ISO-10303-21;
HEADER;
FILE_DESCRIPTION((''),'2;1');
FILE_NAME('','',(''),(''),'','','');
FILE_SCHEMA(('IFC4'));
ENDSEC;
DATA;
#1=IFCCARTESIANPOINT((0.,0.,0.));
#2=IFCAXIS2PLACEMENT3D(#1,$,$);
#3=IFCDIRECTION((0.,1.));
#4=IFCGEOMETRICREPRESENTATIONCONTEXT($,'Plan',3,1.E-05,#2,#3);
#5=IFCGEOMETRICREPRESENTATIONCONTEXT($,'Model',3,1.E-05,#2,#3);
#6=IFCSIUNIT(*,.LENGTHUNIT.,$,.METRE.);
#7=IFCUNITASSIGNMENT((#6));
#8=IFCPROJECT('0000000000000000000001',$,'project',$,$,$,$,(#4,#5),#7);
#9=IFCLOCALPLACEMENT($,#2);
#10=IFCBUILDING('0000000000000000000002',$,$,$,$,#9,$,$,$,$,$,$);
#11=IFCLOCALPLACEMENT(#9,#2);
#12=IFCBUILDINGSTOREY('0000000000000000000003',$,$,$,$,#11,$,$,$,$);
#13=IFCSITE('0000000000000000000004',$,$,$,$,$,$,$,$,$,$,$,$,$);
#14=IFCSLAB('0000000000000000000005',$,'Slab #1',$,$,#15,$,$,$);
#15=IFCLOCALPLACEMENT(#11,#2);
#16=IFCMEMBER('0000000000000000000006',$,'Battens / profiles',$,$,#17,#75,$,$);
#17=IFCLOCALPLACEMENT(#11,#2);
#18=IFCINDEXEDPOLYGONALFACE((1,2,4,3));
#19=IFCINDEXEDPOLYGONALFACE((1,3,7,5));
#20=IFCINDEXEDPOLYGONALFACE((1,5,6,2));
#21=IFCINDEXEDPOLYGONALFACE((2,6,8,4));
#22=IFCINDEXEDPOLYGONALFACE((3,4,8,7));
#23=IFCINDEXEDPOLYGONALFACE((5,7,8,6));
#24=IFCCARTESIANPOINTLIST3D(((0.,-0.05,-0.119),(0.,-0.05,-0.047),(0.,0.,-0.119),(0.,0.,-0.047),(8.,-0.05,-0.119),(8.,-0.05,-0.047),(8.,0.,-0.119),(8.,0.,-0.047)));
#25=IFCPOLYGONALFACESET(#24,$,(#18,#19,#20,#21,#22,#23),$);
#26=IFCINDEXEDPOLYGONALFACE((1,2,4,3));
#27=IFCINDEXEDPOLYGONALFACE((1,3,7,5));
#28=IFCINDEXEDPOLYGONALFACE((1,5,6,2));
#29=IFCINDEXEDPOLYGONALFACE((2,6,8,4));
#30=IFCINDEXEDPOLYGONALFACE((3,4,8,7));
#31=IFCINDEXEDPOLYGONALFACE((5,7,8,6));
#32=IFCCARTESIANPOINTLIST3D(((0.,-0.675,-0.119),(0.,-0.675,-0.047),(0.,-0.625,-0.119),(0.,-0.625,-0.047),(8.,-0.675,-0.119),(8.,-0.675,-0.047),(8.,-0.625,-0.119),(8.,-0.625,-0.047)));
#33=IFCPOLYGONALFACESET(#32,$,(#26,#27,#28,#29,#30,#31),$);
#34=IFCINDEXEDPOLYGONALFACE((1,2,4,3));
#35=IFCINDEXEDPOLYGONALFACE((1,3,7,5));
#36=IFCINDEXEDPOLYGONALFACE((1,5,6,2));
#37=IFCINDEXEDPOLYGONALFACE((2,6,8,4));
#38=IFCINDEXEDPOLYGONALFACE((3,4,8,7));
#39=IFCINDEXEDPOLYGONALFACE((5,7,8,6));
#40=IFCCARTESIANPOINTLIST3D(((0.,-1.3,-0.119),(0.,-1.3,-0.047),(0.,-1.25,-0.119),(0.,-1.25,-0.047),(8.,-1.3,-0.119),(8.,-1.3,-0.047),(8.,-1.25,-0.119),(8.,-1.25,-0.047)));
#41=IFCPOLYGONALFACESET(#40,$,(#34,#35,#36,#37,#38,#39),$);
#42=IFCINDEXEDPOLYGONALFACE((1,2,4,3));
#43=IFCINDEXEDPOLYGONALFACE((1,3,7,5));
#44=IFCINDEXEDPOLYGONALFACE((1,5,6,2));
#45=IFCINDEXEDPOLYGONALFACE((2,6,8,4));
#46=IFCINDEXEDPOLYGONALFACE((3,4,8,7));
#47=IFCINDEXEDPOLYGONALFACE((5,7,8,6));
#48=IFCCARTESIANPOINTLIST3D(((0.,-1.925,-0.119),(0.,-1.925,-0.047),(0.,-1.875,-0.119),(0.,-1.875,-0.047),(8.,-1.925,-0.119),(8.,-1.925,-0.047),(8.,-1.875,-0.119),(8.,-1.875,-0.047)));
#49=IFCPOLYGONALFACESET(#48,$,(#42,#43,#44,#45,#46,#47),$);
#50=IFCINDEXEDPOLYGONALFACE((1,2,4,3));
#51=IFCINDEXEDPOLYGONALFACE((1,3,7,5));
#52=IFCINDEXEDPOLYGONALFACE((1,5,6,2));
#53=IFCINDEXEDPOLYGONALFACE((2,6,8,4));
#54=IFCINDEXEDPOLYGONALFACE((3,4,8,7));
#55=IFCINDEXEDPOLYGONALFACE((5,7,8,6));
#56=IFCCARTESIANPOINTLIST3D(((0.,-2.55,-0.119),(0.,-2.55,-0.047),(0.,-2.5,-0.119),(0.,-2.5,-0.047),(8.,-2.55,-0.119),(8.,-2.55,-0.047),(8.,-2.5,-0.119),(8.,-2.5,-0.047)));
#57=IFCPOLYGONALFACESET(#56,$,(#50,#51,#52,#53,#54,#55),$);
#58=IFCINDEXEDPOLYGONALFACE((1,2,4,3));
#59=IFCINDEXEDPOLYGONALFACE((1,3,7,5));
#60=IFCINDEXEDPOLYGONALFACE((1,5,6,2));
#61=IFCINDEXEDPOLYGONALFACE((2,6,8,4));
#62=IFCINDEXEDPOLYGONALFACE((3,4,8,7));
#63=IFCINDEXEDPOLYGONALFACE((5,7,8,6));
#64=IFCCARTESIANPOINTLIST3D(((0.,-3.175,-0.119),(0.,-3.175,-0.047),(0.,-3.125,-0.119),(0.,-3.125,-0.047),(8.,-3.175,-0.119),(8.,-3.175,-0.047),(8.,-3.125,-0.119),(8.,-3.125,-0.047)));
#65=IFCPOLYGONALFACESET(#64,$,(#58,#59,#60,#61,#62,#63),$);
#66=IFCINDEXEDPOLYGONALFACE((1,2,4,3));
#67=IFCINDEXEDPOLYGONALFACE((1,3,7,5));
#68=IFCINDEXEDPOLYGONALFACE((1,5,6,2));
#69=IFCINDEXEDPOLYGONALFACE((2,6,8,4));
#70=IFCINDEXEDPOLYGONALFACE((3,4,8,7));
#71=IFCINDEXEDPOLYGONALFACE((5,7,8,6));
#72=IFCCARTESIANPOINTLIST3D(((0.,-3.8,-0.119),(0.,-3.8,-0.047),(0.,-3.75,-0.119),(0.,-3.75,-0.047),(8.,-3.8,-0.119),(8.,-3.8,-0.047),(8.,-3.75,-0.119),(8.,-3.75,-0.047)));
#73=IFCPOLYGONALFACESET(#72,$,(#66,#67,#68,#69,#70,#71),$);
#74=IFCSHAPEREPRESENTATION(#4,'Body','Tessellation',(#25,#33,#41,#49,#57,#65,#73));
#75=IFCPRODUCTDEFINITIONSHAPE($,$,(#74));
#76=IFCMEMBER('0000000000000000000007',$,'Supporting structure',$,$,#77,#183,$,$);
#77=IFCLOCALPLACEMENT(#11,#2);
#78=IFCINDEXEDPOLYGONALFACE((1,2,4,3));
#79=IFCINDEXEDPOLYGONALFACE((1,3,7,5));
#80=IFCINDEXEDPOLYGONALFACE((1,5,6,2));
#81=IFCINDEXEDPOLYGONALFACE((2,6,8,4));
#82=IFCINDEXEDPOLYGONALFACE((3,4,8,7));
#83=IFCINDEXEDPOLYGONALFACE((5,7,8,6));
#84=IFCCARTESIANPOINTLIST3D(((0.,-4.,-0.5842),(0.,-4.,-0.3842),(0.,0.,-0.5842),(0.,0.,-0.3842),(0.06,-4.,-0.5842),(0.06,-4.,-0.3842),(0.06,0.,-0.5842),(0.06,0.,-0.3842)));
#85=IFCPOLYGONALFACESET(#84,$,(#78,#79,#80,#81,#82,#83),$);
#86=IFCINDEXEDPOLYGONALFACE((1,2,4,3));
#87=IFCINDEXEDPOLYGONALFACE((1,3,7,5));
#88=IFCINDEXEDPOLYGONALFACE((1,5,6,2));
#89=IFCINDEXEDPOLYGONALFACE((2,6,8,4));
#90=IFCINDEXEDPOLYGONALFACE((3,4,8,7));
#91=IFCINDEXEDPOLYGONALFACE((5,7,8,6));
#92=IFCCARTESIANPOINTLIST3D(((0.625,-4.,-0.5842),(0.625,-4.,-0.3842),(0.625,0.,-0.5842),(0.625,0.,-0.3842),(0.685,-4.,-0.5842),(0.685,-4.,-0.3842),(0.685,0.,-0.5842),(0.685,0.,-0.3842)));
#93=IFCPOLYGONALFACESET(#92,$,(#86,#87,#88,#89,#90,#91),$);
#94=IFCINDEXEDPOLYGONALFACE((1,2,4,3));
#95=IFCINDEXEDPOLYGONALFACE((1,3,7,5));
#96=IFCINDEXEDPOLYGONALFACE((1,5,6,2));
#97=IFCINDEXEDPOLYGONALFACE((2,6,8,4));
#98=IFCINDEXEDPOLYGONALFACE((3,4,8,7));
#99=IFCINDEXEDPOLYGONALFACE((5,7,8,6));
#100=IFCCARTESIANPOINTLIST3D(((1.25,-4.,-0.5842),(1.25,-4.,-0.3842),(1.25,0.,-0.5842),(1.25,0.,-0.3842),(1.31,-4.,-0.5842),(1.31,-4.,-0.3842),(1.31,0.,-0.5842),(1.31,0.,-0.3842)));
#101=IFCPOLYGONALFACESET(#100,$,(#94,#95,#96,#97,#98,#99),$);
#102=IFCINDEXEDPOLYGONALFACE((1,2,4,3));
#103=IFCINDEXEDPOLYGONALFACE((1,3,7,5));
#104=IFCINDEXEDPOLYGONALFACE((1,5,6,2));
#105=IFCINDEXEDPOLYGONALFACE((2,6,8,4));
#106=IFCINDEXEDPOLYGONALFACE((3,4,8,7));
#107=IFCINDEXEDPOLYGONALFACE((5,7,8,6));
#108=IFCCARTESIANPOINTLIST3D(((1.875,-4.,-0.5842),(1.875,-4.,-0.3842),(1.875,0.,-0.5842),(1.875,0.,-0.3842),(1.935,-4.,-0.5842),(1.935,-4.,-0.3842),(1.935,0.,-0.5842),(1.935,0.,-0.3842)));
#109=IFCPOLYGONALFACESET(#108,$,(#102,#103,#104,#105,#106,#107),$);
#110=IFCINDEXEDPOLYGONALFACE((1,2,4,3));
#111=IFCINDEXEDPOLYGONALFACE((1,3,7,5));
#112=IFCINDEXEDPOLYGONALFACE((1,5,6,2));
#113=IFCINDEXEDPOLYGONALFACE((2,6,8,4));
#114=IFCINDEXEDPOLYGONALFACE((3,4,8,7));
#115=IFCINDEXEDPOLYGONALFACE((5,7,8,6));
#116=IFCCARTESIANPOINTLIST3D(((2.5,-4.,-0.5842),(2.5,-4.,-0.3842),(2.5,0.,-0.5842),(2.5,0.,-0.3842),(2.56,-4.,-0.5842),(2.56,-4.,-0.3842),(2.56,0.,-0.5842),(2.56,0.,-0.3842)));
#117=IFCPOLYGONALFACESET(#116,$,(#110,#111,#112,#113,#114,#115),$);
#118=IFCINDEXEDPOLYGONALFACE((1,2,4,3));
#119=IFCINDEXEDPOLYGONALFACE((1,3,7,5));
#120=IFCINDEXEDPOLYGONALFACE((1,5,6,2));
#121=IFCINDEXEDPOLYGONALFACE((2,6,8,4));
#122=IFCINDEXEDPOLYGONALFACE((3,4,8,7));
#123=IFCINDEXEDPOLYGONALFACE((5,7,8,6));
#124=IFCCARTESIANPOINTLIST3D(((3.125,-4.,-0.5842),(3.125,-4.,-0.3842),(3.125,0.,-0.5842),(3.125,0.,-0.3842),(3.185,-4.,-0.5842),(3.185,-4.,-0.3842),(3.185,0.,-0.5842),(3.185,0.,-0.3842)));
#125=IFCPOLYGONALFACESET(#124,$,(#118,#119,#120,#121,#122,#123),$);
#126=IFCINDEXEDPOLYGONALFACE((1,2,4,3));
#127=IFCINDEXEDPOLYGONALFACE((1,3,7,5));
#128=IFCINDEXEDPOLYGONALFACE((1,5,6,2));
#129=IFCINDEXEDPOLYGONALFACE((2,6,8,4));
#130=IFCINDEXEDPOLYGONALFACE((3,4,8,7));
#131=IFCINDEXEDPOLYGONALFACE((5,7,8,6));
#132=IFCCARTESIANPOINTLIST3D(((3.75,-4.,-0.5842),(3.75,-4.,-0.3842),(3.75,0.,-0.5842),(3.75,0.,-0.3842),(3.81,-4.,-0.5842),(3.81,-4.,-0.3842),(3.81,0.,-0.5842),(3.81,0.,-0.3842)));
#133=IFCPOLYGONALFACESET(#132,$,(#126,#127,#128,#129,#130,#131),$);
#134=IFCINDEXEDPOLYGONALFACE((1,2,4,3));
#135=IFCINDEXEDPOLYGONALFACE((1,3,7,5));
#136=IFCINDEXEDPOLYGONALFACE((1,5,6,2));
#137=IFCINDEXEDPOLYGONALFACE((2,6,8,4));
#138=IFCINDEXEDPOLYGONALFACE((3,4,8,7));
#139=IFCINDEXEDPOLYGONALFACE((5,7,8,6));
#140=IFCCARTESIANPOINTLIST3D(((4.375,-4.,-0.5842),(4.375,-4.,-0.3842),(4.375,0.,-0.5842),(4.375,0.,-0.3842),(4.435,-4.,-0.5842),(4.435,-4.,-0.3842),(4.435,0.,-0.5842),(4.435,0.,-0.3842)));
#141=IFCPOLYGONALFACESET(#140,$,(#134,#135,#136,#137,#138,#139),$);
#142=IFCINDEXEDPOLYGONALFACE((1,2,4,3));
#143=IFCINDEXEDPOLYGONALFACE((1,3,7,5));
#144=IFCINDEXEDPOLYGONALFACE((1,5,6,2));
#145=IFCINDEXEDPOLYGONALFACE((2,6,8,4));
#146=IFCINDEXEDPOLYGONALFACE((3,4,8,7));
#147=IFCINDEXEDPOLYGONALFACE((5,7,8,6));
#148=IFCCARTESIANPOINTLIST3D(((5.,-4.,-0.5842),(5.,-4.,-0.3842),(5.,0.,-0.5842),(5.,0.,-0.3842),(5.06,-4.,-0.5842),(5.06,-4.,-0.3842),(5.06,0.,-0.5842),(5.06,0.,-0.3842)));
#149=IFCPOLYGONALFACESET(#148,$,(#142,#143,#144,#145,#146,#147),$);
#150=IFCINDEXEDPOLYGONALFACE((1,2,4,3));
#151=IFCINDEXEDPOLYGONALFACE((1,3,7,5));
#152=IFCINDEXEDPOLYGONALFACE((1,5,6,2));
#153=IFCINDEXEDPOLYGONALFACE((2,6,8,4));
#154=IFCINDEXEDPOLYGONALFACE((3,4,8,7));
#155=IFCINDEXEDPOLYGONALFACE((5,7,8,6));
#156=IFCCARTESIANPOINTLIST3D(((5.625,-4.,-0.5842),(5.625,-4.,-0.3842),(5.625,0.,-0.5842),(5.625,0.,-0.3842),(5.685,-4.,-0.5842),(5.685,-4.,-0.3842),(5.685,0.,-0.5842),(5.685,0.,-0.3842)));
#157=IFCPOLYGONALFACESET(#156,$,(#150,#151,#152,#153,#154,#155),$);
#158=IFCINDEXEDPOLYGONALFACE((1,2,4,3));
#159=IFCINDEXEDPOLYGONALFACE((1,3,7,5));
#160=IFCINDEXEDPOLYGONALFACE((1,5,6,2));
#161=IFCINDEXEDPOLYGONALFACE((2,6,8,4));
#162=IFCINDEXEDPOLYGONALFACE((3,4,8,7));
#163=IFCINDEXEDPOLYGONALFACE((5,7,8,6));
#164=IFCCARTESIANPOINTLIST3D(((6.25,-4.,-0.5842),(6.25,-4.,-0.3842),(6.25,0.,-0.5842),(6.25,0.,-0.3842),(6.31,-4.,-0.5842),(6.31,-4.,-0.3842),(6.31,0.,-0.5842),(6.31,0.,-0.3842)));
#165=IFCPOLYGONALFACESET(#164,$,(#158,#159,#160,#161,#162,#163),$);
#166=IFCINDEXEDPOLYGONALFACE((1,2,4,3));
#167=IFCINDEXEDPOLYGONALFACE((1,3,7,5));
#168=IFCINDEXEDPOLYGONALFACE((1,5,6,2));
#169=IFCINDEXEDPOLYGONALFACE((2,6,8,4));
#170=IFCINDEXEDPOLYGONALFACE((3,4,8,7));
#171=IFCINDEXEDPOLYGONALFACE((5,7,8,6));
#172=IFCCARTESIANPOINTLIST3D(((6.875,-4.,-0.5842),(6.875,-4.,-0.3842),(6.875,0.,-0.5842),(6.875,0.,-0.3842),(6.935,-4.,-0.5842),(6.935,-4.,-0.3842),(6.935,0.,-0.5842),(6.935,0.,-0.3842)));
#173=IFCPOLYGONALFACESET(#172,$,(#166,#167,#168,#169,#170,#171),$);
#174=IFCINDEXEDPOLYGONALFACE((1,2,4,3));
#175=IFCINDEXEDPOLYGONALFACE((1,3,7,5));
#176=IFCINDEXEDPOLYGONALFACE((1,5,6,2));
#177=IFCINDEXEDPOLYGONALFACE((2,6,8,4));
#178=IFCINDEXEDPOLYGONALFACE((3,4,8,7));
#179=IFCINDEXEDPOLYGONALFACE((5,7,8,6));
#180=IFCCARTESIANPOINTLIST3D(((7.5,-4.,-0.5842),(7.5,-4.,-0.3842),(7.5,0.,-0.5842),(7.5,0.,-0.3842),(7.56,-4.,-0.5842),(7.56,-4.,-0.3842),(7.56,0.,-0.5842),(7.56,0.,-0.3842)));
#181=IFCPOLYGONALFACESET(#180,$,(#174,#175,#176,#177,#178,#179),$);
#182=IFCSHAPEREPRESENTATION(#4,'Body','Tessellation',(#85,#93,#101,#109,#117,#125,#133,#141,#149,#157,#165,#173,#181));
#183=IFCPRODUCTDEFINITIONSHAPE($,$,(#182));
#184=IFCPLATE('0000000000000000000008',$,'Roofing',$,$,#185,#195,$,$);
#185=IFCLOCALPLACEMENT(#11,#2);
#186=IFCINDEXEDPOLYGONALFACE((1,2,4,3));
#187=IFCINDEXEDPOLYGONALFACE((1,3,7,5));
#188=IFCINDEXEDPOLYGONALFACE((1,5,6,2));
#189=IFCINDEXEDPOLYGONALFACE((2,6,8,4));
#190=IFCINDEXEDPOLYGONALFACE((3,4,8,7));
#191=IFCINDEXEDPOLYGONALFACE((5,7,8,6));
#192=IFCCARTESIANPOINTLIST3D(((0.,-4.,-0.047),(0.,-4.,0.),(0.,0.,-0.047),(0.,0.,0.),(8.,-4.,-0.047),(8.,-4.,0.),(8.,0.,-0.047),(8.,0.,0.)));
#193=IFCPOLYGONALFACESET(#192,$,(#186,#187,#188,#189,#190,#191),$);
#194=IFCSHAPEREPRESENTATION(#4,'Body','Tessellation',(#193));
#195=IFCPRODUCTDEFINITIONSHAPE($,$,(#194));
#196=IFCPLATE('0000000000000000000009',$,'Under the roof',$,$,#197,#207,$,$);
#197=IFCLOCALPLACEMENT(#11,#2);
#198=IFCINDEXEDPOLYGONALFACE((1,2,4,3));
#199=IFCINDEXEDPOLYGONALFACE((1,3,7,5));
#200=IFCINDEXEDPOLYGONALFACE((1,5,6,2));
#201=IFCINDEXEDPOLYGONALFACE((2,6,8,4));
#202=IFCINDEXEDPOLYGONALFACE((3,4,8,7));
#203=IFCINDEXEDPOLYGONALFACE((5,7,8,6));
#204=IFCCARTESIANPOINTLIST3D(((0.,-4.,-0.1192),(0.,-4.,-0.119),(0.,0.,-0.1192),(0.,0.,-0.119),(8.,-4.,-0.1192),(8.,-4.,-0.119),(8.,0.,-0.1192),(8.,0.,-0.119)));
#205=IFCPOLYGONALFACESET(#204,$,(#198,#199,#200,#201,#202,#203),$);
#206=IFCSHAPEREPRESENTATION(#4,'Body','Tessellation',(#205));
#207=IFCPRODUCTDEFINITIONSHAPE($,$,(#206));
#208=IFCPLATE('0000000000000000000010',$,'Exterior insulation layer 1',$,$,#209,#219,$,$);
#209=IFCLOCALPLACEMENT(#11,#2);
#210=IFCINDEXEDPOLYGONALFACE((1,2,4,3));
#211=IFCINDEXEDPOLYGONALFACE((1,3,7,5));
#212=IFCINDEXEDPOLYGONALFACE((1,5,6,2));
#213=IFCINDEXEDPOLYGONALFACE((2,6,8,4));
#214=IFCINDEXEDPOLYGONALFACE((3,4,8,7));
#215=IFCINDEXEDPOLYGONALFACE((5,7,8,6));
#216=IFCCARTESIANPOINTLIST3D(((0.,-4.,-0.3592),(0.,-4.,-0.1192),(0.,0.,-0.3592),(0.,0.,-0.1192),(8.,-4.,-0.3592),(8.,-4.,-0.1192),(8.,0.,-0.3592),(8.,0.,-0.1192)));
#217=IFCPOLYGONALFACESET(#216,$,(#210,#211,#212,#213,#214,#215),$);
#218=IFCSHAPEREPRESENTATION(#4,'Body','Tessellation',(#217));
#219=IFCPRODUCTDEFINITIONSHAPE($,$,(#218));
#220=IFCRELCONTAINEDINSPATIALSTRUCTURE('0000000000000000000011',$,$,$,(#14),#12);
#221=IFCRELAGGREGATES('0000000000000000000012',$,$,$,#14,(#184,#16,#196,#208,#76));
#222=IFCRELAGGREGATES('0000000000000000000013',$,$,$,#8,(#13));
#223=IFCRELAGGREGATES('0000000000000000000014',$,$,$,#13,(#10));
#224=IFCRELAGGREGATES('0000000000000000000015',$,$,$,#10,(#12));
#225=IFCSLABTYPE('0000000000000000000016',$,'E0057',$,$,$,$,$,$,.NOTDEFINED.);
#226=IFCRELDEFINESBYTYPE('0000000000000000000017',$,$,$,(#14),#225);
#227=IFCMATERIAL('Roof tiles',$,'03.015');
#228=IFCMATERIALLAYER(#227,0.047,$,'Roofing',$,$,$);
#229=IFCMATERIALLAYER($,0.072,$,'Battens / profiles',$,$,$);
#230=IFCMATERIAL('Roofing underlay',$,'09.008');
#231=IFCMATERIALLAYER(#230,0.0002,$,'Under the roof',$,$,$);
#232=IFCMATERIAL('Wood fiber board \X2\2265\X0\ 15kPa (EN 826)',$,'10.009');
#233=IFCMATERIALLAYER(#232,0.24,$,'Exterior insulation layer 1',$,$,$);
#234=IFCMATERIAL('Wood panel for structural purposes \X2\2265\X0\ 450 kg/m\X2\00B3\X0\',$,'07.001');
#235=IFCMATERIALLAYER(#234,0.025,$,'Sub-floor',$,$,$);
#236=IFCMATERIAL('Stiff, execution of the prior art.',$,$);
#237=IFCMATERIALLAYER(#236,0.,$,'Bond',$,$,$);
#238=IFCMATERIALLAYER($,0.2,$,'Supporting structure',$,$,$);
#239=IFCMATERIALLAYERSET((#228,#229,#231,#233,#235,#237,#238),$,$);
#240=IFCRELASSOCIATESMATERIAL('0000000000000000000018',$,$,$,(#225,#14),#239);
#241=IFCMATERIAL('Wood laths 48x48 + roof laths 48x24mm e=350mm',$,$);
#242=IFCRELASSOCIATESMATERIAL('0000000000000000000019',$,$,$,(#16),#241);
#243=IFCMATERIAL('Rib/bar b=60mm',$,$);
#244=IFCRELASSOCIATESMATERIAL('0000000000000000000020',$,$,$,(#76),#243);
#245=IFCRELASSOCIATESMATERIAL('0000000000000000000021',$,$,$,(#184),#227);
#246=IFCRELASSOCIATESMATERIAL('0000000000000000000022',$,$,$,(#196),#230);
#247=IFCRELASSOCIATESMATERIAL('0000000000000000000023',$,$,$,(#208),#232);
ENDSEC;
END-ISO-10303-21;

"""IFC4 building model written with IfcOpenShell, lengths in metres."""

from ifc_helpers import new_model, si_unit, direction, frame, frame_2d, origin, origin_with_axes, place, context, project, spatial, rectangle, extrude, material, layer, layer_set, type_object, element, aggregate, save


model = new_model("IFC4")

# Units and contexts
plan_context = context("Plan", 3, precision=1e-05, world=origin(), true_north=direction((0.0, 1.0)))
model_context = context("Model", 3, precision=1e-05, world=origin(), true_north=direction((0.0, 1.0)))
ifc_project = project(units=[si_unit("LENGTHUNIT", "METRE")], contexts=[plan_context, model_context])

# Site, building, storey
site = spatial("IfcSite", under=ifc_project)
building_placement = place(None, origin())
building = spatial("IfcBuilding", under=site, at=building_placement)
storey_placement = place(building_placement, origin())
storey = spatial("IfcBuildingStorey", under=building, at=storey_placement)

# Slab, members, plates
ifc_material_1 = material(Name="Roof tiles", Category="03.015")
ifc_layer_1 = layer(ifc_material_1, 0.047, Name="Roofing")
ifc_layer_2 = layer(None, 0.072, Name="Battens / profiles")
ifc_material_2 = material(Name="Roofing underlay", Category="09.008")
ifc_layer_3 = layer(ifc_material_2, 0.0002, Name="Under the roof")
ifc_material_3 = material(Name="Wood fiber board ≥ 15kPa (EN 826)", Category="10.009")
ifc_layer_4 = layer(ifc_material_3, 0.24, Name="Exterior insulation layer 1")
ifc_material_4 = material(Name="Wood panel for structural purposes ≥ 450 kg/m³", Category="07.001")
ifc_layer_5 = layer(ifc_material_4, 0.025, Name="Sub-floor")
ifc_material_5 = material(Name="Stiff, execution of the prior art.")
ifc_layer_6 = layer(ifc_material_5, 0.0, Name="Bond")
ifc_layer_7 = layer(None, 0.2, Name="Supporting structure")
ifc_layer_set = layer_set([ifc_layer_1, ifc_layer_2, ifc_layer_3, ifc_layer_4, ifc_layer_5, ifc_layer_6, ifc_layer_7])
slab_type = type_object("IfcSlabType", Name="E0057", PredefinedType="NOTDEFINED", material=ifc_layer_set)
slab_placement = place(None, frame((0.0, 0.0, 0.0), z_axis=(0.0, 0.0, -1.0), x_axis=(1.0, 0.0, 0.0)))
slab = element("IfcSlab", 1, at=slab_placement, inside=storey, type_object=slab_type, material=ifc_layer_set, Name="Slab #1")
ifc_material_6 = material(Name="Wood laths 48x48 + roof laths 48x24mm e=350mm")
member_1_placement = place(slab_placement, origin())
member_1 = element("IfcMember", 2, at=member_1_placement, material=ifc_material_6, Name="Battens / profiles", context=plan_context, shape_type="SweptSolid", body=[
    extrude(rectangle(XDim=0.05, YDim=0.072, at=frame_2d((0.025, 0.036), x_axis=(1.0, 0.0))), frame((0.0, 0.0, 0.047), z_axis=(1.0, 0.0, 0.0), x_axis=(0.0, 1.0, 0.0)), (0.0, 0.0, 1.0), 8.0),
    extrude(rectangle(XDim=0.05, YDim=0.072, at=frame_2d((0.025, 0.036), x_axis=(1.0, 0.0))), frame((0.0, 0.625, 0.047), z_axis=(1.0, 0.0, 0.0), x_axis=(0.0, 1.0, 0.0)), (0.0, 0.0, 1.0), 8.0),
    extrude(rectangle(XDim=0.05, YDim=0.072, at=frame_2d((0.025, 0.036), x_axis=(1.0, 0.0))), frame((0.0, 1.25, 0.047), z_axis=(1.0, 0.0, 0.0), x_axis=(0.0, 1.0, 0.0)), (0.0, 0.0, 1.0), 8.0),
    extrude(rectangle(XDim=0.05, YDim=0.072, at=frame_2d((0.025, 0.036), x_axis=(1.0, 0.0))), frame((0.0, 1.875, 0.047), z_axis=(1.0, 0.0, 0.0), x_axis=(0.0, 1.0, 0.0)), (0.0, 0.0, 1.0), 8.0),
    extrude(rectangle(XDim=0.05, YDim=0.072, at=frame_2d((0.025, 0.036), x_axis=(1.0, 0.0))), frame((0.0, 2.5, 0.047), z_axis=(1.0, 0.0, 0.0), x_axis=(0.0, 1.0, 0.0)), (0.0, 0.0, 1.0), 8.0),
    extrude(rectangle(XDim=0.05, YDim=0.072, at=frame_2d((0.025, 0.036), x_axis=(1.0, 0.0))), frame((0.0, 3.125, 0.047), z_axis=(1.0, 0.0, 0.0), x_axis=(0.0, 1.0, 0.0)), (0.0, 0.0, 1.0), 8.0),
    extrude(rectangle(XDim=0.05, YDim=0.072, at=frame_2d((0.025, 0.036), x_axis=(1.0, 0.0))), frame((0.0, 3.75, 0.047), z_axis=(1.0, 0.0, 0.0), x_axis=(0.0, 1.0, 0.0)), (0.0, 0.0, 1.0), 8.0),
])
ifc_material_7 = material(Name="Rib/bar b=60mm")
member_2_placement = place(slab_placement, origin())
member_2 = element("IfcMember", 3, at=member_2_placement, material=ifc_material_7, Name="Supporting structure", context=plan_context, shape_type="SweptSolid", body=[
    extrude(rectangle(XDim=0.06, YDim=0.2, at=frame_2d((0.03, 0.1), x_axis=(1.0, 0.0))), frame((0.0, 4.0, 0.3842), z_axis=(0.0, -1.0, 0.0), x_axis=(1.0, 0.0, 0.0)), (0.0, 0.0, 1.0), 4.0),
    extrude(rectangle(XDim=0.06, YDim=0.2, at=frame_2d((0.03, 0.1), x_axis=(1.0, 0.0))), frame((0.625, 4.0, 0.3842), z_axis=(0.0, -1.0, 0.0), x_axis=(1.0, 0.0, 0.0)), (0.0, 0.0, 1.0), 4.0),
    extrude(rectangle(XDim=0.06, YDim=0.2, at=frame_2d((0.03, 0.1), x_axis=(1.0, 0.0))), frame((1.25, 4.0, 0.3842), z_axis=(0.0, -1.0, 0.0), x_axis=(1.0, 0.0, 0.0)), (0.0, 0.0, 1.0), 4.0),
    extrude(rectangle(XDim=0.06, YDim=0.2, at=frame_2d((0.03, 0.1), x_axis=(1.0, 0.0))), frame((1.875, 4.0, 0.3842), z_axis=(0.0, -1.0, 0.0), x_axis=(1.0, 0.0, 0.0)), (0.0, 0.0, 1.0), 4.0),
    extrude(rectangle(XDim=0.06, YDim=0.2, at=frame_2d((0.03, 0.1), x_axis=(1.0, 0.0))), frame((2.5, 4.0, 0.3842), z_axis=(0.0, -1.0, 0.0), x_axis=(1.0, 0.0, 0.0)), (0.0, 0.0, 1.0), 4.0),
    extrude(rectangle(XDim=0.06, YDim=0.2, at=frame_2d((0.03, 0.1), x_axis=(1.0, 0.0))), frame((3.125, 4.0, 0.3842), z_axis=(0.0, -1.0, 0.0), x_axis=(1.0, 0.0, 0.0)), (0.0, 0.0, 1.0), 4.0),
    extrude(rectangle(XDim=0.06, YDim=0.2, at=frame_2d((0.03, 0.1), x_axis=(1.0, 0.0))), frame((3.75, 4.0, 0.3842), z_axis=(0.0, -1.0, 0.0), x_axis=(1.0, 0.0, 0.0)), (0.0, 0.0, 1.0), 4.0),
    extrude(rectangle(XDim=0.06, YDim=0.2, at=frame_2d((0.03, 0.1), x_axis=(1.0, 0.0))), frame((4.375, 4.0, 0.3842), z_axis=(0.0, -1.0, 0.0), x_axis=(1.0, 0.0, 0.0)), (0.0, 0.0, 1.0), 4.0),
    extrude(rectangle(XDim=0.06, YDim=0.2, at=frame_2d((0.03, 0.1), x_axis=(1.0, 0.0))), frame((5.0, 4.0, 0.3842), z_axis=(0.0, -1.0, 0.0), x_axis=(1.0, 0.0, 0.0)), (0.0, 0.0, 1.0), 4.0),
    extrude(rectangle(XDim=0.06, YDim=0.2, at=frame_2d((0.03, 0.1), x_axis=(1.0, 0.0))), frame((5.625, 4.0, 0.3842), z_axis=(0.0, -1.0, 0.0), x_axis=(1.0, 0.0, 0.0)), (0.0, 0.0, 1.0), 4.0),
    extrude(rectangle(XDim=0.06, YDim=0.2, at=frame_2d((0.03, 0.1), x_axis=(1.0, 0.0))), frame((6.25, 4.0, 0.3842), z_axis=(0.0, -1.0, 0.0), x_axis=(1.0, 0.0, 0.0)), (0.0, 0.0, 1.0), 4.0),
    extrude(rectangle(XDim=0.06, YDim=0.2, at=frame_2d((0.03, 0.1), x_axis=(1.0, 0.0))), frame((6.875, 4.0, 0.3842), z_axis=(0.0, -1.0, 0.0), x_axis=(1.0, 0.0, 0.0)), (0.0, 0.0, 1.0), 4.0),
    extrude(rectangle(XDim=0.06, YDim=0.2, at=frame_2d((0.03, 0.1), x_axis=(1.0, 0.0))), frame((7.5, 4.0, 0.3842), z_axis=(0.0, -1.0, 0.0), x_axis=(1.0, 0.0, 0.0)), (0.0, 0.0, 1.0), 4.0),
])
plate_1_placement = place(slab_placement, origin())
plate_1 = element("IfcPlate", 4, at=plate_1_placement, material=ifc_material_1, Name="Roofing", context=plan_context, shape_type="SweptSolid", body=[
    extrude(rectangle(XDim=8.0, YDim=4.0, at=frame_2d((4.0, 2.0), x_axis=(1.0, 0.0))), origin_with_axes(), (0.0, 0.0, 1.0), 0.047),
])
plate_2_placement = place(slab_placement, origin())
plate_2 = element("IfcPlate", 5, at=plate_2_placement, material=ifc_material_2, Name="Under the roof", context=plan_context, shape_type="SweptSolid", body=[
    extrude(rectangle(XDim=8.0, YDim=4.0, at=frame_2d((4.0, 2.0), x_axis=(1.0, 0.0))), frame((0.0, 0.0, 0.119), z_axis=(0.0, 0.0, 1.0), x_axis=(1.0, 0.0, 0.0)), (0.0, 0.0, 1.0), 0.0002),
])
plate_3_placement = place(slab_placement, origin())
plate_3 = element("IfcPlate", 6, at=plate_3_placement, material=ifc_material_3, Name="Exterior insulation layer 1", context=plan_context, shape_type="SweptSolid", body=[
    extrude(rectangle(XDim=8.0, YDim=4.0, at=frame_2d((4.0, 2.0), x_axis=(1.0, 0.0))), frame((0.0, 0.0, 0.1192), z_axis=(0.0, 0.0, 1.0), x_axis=(1.0, 0.0, 0.0)), (0.0, 0.0, 1.0), 0.24),
])
aggregate(slab, [plate_1, member_1, plate_2, plate_3, member_2])

save(model, "model.ifc")
